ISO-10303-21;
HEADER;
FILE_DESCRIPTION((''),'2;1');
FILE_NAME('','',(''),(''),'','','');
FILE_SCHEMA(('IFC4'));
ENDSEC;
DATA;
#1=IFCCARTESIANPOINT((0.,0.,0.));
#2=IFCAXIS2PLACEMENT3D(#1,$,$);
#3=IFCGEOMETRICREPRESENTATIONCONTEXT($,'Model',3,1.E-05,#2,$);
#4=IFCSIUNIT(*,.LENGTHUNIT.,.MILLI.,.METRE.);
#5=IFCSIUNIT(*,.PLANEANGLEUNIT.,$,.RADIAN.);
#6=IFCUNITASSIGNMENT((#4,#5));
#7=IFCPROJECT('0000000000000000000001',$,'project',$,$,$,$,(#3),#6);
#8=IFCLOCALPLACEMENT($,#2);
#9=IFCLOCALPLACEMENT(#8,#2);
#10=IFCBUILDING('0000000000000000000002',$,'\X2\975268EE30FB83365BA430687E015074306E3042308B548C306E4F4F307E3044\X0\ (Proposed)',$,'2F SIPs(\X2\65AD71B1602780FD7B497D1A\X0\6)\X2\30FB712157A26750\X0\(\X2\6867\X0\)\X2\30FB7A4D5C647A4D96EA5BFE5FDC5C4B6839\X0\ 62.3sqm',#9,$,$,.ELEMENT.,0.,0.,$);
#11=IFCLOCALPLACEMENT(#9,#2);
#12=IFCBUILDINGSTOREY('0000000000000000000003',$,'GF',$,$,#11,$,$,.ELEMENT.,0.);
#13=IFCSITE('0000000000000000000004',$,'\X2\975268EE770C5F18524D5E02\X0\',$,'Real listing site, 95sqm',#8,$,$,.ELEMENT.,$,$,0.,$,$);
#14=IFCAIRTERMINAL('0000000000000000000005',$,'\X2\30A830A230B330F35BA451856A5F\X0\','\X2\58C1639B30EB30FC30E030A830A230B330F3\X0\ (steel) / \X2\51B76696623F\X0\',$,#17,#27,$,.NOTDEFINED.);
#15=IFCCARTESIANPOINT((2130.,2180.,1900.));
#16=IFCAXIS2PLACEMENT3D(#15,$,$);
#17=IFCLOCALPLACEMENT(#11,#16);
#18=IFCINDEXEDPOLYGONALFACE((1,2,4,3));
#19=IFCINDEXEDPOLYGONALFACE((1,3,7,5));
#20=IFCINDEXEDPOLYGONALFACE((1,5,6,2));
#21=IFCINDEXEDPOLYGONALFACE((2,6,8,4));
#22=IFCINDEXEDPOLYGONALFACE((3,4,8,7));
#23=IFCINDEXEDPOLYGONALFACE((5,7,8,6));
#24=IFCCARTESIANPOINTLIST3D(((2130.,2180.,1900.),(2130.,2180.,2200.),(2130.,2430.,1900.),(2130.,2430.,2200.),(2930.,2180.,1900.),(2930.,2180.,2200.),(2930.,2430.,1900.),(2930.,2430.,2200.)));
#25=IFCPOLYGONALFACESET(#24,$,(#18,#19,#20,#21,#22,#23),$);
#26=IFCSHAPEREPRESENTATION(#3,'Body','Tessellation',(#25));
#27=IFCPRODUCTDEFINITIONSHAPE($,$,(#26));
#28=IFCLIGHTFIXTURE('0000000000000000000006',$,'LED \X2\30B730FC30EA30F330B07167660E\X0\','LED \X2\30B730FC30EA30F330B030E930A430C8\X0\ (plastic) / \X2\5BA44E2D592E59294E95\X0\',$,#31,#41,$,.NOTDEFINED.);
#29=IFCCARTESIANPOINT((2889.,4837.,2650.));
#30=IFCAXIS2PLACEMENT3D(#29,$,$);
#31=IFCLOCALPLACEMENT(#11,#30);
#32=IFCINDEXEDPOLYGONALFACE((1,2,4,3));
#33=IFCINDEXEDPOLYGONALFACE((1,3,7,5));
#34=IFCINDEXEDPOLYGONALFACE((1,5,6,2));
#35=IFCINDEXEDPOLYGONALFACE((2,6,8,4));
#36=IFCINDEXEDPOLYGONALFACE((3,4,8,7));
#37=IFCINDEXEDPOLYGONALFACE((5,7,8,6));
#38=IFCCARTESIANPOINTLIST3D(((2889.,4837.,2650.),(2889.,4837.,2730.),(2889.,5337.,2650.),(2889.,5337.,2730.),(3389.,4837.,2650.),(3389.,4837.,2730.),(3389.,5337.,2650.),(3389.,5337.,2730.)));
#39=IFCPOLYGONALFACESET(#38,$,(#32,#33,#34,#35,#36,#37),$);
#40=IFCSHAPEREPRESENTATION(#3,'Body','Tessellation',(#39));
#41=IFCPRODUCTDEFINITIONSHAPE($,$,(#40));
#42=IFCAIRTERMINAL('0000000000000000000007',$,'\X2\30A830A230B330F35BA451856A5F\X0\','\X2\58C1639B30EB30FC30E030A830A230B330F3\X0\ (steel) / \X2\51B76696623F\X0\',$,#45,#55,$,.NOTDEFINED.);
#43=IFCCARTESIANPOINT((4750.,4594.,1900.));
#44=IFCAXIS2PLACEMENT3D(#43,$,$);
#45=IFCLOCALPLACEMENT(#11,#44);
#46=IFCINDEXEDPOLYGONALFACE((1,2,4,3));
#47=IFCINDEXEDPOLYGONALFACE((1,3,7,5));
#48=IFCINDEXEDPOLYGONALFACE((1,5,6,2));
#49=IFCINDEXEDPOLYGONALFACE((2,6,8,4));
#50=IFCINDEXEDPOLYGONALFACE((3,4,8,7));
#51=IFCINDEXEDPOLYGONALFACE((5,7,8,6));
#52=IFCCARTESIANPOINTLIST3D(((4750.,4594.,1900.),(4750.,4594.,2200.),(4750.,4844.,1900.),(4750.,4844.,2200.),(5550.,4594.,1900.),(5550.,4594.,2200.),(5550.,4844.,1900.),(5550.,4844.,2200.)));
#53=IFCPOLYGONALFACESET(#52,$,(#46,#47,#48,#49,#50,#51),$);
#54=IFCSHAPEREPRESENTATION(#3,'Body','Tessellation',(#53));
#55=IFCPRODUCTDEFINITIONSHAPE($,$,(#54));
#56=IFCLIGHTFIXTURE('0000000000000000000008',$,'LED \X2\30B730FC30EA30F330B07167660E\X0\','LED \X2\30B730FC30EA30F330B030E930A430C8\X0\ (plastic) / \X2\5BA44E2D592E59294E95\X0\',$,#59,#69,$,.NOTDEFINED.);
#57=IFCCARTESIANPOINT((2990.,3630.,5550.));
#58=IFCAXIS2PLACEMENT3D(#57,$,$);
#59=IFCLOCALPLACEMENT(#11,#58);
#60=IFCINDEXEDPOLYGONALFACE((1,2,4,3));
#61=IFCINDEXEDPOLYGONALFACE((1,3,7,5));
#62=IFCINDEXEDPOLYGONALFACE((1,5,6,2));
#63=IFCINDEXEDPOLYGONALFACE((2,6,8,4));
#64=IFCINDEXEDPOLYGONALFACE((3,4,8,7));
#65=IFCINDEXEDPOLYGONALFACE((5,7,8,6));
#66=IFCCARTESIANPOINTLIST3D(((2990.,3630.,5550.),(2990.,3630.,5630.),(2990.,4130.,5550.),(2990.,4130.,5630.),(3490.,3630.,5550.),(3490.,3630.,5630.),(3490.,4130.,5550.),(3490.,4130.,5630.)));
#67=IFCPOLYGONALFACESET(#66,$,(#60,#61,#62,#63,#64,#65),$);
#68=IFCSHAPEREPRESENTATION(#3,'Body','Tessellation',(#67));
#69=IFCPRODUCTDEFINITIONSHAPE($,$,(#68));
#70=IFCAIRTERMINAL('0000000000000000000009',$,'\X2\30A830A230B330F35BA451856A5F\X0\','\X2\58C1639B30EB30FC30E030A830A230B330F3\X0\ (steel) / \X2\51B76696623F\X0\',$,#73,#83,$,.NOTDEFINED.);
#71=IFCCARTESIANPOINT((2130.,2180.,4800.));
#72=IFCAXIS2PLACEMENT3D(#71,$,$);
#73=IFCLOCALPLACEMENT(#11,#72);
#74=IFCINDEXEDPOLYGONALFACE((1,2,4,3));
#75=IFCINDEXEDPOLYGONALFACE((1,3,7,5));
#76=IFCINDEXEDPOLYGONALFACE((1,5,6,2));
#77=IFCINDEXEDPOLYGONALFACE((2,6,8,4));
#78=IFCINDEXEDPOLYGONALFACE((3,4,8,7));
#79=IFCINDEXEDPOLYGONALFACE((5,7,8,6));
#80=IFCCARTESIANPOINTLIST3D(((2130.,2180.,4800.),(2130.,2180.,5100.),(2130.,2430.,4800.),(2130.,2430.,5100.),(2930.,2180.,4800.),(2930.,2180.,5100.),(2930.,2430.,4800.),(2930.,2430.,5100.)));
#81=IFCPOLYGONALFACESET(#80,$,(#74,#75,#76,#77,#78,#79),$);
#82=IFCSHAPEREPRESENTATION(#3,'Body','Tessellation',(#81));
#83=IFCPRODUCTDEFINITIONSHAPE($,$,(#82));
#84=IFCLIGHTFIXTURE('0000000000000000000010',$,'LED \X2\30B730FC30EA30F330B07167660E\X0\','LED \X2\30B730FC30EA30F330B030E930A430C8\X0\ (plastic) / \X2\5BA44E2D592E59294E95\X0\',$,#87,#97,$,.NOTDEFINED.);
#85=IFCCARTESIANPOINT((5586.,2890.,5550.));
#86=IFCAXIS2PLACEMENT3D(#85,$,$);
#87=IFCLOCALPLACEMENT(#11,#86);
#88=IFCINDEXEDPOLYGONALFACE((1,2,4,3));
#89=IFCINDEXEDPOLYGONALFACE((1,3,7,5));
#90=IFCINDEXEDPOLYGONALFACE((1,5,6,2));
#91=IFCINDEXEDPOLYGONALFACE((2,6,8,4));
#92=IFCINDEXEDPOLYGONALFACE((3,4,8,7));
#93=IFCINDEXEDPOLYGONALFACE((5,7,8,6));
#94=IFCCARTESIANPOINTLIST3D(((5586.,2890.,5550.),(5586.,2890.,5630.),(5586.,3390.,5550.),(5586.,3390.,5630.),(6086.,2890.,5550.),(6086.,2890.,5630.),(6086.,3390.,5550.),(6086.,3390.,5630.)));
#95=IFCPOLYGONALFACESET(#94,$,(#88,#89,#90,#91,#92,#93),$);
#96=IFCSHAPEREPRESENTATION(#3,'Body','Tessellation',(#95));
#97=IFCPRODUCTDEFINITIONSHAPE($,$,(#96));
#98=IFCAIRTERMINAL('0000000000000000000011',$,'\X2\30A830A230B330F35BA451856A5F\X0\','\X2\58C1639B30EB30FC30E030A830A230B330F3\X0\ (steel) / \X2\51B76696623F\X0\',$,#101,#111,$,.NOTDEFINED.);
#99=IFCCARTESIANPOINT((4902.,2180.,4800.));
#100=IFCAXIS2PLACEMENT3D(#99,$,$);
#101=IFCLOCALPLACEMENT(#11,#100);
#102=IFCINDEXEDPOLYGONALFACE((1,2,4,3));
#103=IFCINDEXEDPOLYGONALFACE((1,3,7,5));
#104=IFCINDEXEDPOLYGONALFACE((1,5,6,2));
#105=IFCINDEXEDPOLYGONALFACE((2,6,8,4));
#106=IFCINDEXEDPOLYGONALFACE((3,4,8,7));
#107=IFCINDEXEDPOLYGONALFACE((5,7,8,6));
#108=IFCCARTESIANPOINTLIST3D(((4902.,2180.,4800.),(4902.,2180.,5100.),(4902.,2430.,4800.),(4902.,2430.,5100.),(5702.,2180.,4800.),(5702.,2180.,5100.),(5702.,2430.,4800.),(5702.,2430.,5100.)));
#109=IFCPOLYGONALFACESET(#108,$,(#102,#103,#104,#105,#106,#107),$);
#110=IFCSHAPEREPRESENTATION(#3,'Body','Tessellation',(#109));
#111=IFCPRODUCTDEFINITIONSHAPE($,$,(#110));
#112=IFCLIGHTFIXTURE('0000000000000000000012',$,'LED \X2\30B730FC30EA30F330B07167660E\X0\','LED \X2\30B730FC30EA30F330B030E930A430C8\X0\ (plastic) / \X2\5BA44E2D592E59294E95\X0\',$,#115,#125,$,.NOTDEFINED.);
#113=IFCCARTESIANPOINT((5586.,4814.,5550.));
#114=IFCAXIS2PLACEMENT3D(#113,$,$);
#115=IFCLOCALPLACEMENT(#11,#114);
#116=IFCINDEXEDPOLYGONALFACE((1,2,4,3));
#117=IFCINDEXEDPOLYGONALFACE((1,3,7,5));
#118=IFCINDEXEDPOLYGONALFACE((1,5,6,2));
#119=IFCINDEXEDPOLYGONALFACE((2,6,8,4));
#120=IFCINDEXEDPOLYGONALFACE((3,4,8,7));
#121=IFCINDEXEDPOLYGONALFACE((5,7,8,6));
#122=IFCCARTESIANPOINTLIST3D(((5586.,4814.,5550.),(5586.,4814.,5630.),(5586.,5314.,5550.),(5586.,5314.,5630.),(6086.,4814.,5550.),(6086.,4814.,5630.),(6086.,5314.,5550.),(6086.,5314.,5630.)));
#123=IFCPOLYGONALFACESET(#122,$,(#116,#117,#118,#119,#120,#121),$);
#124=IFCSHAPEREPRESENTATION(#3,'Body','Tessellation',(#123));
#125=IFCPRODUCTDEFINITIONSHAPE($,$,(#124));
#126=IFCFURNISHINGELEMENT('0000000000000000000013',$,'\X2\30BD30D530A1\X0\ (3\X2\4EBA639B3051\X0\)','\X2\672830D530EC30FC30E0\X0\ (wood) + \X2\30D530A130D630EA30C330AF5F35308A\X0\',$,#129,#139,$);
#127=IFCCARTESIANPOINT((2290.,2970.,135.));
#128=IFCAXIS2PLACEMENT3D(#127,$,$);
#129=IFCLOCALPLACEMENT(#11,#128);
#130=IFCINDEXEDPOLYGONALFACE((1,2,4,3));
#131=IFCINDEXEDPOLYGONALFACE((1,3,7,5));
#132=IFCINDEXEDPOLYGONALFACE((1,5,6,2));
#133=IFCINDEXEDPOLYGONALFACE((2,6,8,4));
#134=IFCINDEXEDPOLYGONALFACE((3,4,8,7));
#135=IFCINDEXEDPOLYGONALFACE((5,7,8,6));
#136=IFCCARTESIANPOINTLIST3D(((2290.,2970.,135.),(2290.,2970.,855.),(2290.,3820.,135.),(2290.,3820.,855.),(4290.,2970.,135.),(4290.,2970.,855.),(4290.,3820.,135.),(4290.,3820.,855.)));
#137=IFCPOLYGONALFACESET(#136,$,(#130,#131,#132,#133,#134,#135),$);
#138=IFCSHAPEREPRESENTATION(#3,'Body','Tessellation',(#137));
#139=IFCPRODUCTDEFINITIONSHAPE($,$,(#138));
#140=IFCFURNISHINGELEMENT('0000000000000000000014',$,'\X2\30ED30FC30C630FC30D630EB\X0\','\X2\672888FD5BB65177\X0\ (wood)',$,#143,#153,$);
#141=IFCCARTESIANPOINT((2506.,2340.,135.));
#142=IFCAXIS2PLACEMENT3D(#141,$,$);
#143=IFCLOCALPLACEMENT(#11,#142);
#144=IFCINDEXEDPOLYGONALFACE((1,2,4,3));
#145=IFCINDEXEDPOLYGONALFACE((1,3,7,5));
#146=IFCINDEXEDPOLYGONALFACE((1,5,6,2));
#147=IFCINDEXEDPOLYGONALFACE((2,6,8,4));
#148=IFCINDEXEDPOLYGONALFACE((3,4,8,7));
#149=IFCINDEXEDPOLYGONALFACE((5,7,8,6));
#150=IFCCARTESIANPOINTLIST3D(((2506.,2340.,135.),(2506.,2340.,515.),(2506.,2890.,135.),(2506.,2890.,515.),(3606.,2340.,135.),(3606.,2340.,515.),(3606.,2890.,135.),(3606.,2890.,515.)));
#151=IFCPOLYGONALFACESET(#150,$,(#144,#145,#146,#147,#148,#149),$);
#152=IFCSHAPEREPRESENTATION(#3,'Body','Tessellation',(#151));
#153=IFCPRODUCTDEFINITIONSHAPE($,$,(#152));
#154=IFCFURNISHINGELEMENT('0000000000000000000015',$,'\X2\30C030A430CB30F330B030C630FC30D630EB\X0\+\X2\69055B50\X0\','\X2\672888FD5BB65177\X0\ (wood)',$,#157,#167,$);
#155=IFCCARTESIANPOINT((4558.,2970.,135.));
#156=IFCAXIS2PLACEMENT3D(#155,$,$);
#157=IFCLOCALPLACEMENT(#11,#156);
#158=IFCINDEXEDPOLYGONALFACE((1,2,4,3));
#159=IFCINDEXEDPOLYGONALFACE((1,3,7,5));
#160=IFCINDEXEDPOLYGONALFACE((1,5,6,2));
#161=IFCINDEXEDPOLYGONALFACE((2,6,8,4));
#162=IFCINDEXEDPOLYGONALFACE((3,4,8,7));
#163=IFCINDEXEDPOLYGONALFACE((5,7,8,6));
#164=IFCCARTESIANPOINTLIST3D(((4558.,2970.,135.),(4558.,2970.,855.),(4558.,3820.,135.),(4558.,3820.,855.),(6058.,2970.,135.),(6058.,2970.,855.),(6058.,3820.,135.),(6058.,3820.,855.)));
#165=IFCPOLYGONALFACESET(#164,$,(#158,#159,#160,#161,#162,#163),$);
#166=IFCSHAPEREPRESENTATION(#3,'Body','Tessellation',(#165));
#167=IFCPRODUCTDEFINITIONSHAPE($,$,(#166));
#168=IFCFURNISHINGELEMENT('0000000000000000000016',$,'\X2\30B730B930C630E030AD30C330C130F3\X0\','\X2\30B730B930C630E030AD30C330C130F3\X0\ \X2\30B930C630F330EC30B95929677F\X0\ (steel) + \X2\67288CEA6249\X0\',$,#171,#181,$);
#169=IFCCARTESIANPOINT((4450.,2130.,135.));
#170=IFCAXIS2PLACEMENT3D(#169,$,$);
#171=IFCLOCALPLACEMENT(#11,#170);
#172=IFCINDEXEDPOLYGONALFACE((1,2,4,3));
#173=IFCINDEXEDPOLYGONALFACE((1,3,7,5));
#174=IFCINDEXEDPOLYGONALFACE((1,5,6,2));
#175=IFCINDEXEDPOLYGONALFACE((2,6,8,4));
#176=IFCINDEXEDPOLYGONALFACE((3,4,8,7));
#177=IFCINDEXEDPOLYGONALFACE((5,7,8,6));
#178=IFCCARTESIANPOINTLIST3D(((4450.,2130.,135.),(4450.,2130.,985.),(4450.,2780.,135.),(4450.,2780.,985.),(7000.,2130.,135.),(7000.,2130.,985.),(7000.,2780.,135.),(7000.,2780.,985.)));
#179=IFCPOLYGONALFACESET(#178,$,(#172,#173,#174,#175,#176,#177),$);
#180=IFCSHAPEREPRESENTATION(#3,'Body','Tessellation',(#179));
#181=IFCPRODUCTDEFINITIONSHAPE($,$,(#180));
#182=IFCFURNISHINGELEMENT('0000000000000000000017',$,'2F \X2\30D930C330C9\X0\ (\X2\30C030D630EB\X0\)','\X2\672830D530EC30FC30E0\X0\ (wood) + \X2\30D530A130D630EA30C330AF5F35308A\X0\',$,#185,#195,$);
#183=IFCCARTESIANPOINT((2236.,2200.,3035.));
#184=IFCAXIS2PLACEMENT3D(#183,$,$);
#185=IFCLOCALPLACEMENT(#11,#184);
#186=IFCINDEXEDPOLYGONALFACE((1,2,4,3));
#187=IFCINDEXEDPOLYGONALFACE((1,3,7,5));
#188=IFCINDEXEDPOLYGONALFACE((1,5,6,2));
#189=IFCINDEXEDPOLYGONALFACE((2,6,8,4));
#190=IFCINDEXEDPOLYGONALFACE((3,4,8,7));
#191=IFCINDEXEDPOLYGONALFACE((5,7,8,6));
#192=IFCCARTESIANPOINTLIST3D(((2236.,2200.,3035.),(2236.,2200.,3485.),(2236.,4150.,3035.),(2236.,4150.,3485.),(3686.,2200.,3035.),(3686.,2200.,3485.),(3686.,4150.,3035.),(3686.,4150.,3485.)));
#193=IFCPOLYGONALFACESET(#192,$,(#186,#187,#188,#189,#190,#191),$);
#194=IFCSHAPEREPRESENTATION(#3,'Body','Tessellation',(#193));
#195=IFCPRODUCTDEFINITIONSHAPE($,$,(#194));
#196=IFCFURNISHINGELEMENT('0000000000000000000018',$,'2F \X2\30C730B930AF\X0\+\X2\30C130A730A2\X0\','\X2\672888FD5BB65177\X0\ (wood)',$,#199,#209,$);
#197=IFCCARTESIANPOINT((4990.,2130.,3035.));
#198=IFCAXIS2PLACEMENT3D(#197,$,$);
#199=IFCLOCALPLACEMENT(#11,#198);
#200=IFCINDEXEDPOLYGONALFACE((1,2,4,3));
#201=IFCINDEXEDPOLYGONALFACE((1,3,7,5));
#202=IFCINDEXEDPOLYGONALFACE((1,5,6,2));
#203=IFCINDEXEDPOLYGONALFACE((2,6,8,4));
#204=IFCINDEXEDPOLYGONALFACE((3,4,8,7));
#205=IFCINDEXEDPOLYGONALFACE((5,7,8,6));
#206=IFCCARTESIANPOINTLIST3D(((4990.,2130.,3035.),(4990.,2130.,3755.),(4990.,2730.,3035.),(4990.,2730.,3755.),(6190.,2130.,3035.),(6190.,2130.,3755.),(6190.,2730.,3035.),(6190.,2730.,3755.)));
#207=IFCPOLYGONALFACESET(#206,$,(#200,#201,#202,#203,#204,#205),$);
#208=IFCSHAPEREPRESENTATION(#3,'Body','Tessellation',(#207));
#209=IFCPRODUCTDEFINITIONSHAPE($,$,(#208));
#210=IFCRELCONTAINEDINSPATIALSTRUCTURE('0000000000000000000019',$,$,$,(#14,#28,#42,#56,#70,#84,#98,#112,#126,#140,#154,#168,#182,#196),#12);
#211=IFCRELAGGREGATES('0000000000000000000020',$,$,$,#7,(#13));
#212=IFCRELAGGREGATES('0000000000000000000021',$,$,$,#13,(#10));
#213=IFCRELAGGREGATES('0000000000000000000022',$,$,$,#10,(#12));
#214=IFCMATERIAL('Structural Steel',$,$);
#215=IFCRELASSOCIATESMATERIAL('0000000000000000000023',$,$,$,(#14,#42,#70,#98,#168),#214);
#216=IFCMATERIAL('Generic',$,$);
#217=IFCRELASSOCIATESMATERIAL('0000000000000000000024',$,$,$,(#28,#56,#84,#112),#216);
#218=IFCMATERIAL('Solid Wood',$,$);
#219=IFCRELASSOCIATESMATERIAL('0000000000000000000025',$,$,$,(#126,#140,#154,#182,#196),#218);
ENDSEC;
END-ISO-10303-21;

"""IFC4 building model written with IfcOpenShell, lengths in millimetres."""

from ifc_helpers import new_model, si_unit, frame, frame_2d, origin, place, context, project, spatial, rectangle, extrude, material, element, save


model = new_model("IFC4")

# Units and contexts
model_context = context("Model", 3, precision=1e-05, world=origin())
ifc_project = project(units=[si_unit("LENGTHUNIT", "METRE", prefix="MILLI"), si_unit("PLANEANGLEUNIT", "RADIAN")], contexts=[model_context])

# Site, building, storey
site_placement = place(None, origin())
site = spatial("IfcSite", under=ifc_project, at=site_placement, Name="青森県弘前市", ObjectType="Real listing site, 95sqm", CompositionType="ELEMENT", RefElevation=0.0)
building_placement = place(site_placement, origin())
building = spatial("IfcBuilding", under=site, at=building_placement, Name="青森・茶室と縁側のある和の住まい (Proposed)", ObjectType="2F SIPs(断熱性能等級6)・無垢材(桧)・積層積雪対応屋根 62.3sqm", CompositionType="ELEMENT", ElevationOfRefHeight=0.0, ElevationOfTerrain=0.0)
storey_placement = place(building_placement, origin())
storey = spatial("IfcBuildingStorey", under=building, at=storey_placement, Name="GF", CompositionType="ELEMENT", Elevation=0.0)

# Shared definitions
ifc_material_1 = material(Name="Solid Wood")

# Shared definitions
ifc_material_2 = material(Name="Structural Steel")

# Shared definitions
ifc_material_3 = material(Name="Generic")

# Air terminal
air_terminal_1_placement = place(storey_placement, frame((2130.0, 2180.0, 1900.0)))
element("IfcAirTerminal", 1, at=air_terminal_1_placement, inside=storey, material=ifc_material_2, Name="エアコン室内機", Description="壁掛ルームエアコン (steel) / 冷暖房", PredefinedType="NOTDEFINED", context=model_context, shape_type="SweptSolid", body=[
    extrude(rectangle(XDim=800.0, YDim=250.0, at=frame_2d((400.0, 125.0))), frame((2130.0, 2180.0, 1900.0)), (0.0, 0.0, 1.0), 300.0),
])

# Light fixture
light_fixture_1_placement = place(storey_placement, frame((2889.0, 4837.0, 2650.0)))
element("IfcLightFixture", 2, at=light_fixture_1_placement, inside=storey, material=ifc_material_3, Name="LED シーリング照明", Description="LED シーリングライト (plastic) / 室中央天井", PredefinedType="NOTDEFINED", context=model_context, shape_type="SweptSolid", body=[
    extrude(rectangle(XDim=500.0, YDim=500.0, at=frame_2d((250.0, 250.0))), frame((2889.0, 4837.0, 2650.0)), (0.0, 0.0, 1.0), 80.0),
])

# Air terminal
air_terminal_2_placement = place(storey_placement, frame((4750.0, 4594.0, 1900.0)))
element("IfcAirTerminal", 3, at=air_terminal_2_placement, inside=storey, material=ifc_material_2, Name="エアコン室内機", Description="壁掛ルームエアコン (steel) / 冷暖房", PredefinedType="NOTDEFINED", context=model_context, shape_type="SweptSolid", body=[
    extrude(rectangle(XDim=800.0, YDim=250.0, at=frame_2d((400.0, 125.0))), frame((4750.0, 4594.0, 1900.0)), (0.0, 0.0, 1.0), 300.0),
])

# Light fixture
light_fixture_2_placement = place(storey_placement, frame((2990.0, 3630.0, 5550.0)))
element("IfcLightFixture", 4, at=light_fixture_2_placement, inside=storey, material=ifc_material_3, Name="LED シーリング照明", Description="LED シーリングライト (plastic) / 室中央天井", PredefinedType="NOTDEFINED", context=model_context, shape_type="SweptSolid", body=[
    extrude(rectangle(XDim=500.0, YDim=500.0, at=frame_2d((250.0, 250.0))), frame((2990.0, 3630.0, 5550.0)), (0.0, 0.0, 1.0), 80.0),
])

# Air terminal
air_terminal_3_placement = place(storey_placement, frame((2130.0, 2180.0, 4800.0)))
element("IfcAirTerminal", 5, at=air_terminal_3_placement, inside=storey, material=ifc_material_2, Name="エアコン室内機", Description="壁掛ルームエアコン (steel) / 冷暖房", PredefinedType="NOTDEFINED", context=model_context, shape_type="SweptSolid", body=[
    extrude(rectangle(XDim=800.0, YDim=250.0, at=frame_2d((400.0, 125.0))), frame((2130.0, 2180.0, 4800.0)), (0.0, 0.0, 1.0), 300.0),
])

# Light fixture
light_fixture_3_placement = place(storey_placement, frame((5586.0, 2890.0, 5550.0)))
element("IfcLightFixture", 6, at=light_fixture_3_placement, inside=storey, material=ifc_material_3, Name="LED シーリング照明", Description="LED シーリングライト (plastic) / 室中央天井", PredefinedType="NOTDEFINED", context=model_context, shape_type="SweptSolid", body=[
    extrude(rectangle(XDim=500.0, YDim=500.0, at=frame_2d((250.0, 250.0))), frame((5586.0, 2890.0, 5550.0)), (0.0, 0.0, 1.0), 80.0),
])

# Air terminal
air_terminal_4_placement = place(storey_placement, frame((4902.0, 2180.0, 4800.0)))
element("IfcAirTerminal", 7, at=air_terminal_4_placement, inside=storey, material=ifc_material_2, Name="エアコン室内機", Description="壁掛ルームエアコン (steel) / 冷暖房", PredefinedType="NOTDEFINED", context=model_context, shape_type="SweptSolid", body=[
    extrude(rectangle(XDim=800.0, YDim=250.0, at=frame_2d((400.0, 125.0))), frame((4902.0, 2180.0, 4800.0)), (0.0, 0.0, 1.0), 300.0),
])

# Light fixture
light_fixture_4_placement = place(storey_placement, frame((5586.0, 4814.0, 5550.0)))
element("IfcLightFixture", 8, at=light_fixture_4_placement, inside=storey, material=ifc_material_3, Name="LED シーリング照明", Description="LED シーリングライト (plastic) / 室中央天井", PredefinedType="NOTDEFINED", context=model_context, shape_type="SweptSolid", body=[
    extrude(rectangle(XDim=500.0, YDim=500.0, at=frame_2d((250.0, 250.0))), frame((5586.0, 4814.0, 5550.0)), (0.0, 0.0, 1.0), 80.0),
])

# Furnishing elements
furnishing_1_placement = place(storey_placement, frame((2290.0, 2970.0, 135.0)))
element("IfcFurnishingElement", 9, at=furnishing_1_placement, inside=storey, material=ifc_material_1, Name="ソファ (3人掛け)", Description="木フレーム (wood) + ファブリック張り", context=model_context, shape_type="SweptSolid", body=[
    extrude(rectangle(XDim=2000.0, YDim=850.0, at=frame_2d((1000.0, 425.0))), frame((2290.0, 2970.0, 135.0)), (0.0, 0.0, 1.0), 720.0),
])
furnishing_2_placement = place(storey_placement, frame((2506.0, 2340.0, 135.0)))
element("IfcFurnishingElement", 10, at=furnishing_2_placement, inside=storey, material=ifc_material_1, Name="ローテーブル", Description="木製家具 (wood)", context=model_context, shape_type="SweptSolid", body=[
    extrude(rectangle(XDim=1100.0, YDim=550.0, at=frame_2d((550.0, 275.0))), frame((2506.0, 2340.0, 135.0)), (0.0, 0.0, 1.0), 380.0),
])
furnishing_3_placement = place(storey_placement, frame((4558.0, 2970.0, 135.0)))
element("IfcFurnishingElement", 11, at=furnishing_3_placement, inside=storey, material=ifc_material_1, Name="ダイニングテーブル+椅子", Description="木製家具 (wood)", context=model_context, shape_type="SweptSolid", body=[
    extrude(rectangle(XDim=1500.0, YDim=850.0, at=frame_2d((750.0, 425.0))), frame((4558.0, 2970.0, 135.0)), (0.0, 0.0, 1.0), 720.0),
])
furnishing_4_placement = place(storey_placement, frame((4450.0, 2130.0, 135.0)))
element("IfcFurnishingElement", 12, at=furnishing_4_placement, inside=storey, material=ifc_material_2, Name="システムキッチン", Description="システムキッチン ステンレス天板 (steel) + 木質扉", context=model_context, shape_type="SweptSolid", body=[
    extrude(rectangle(XDim=2550.0, YDim=650.0, at=frame_2d((1275.0, 325.0))), frame((4450.0, 2130.0, 135.0)), (0.0, 0.0, 1.0), 850.0),
])
furnishing_5_placement = place(storey_placement, frame((2236.0, 2200.0, 3035.0)))
element("IfcFurnishingElement", 13, at=furnishing_5_placement, inside=storey, material=ifc_material_1, Name="2F ベッド (ダブル)", Description="木フレーム (wood) + ファブリック張り", context=model_context, shape_type="SweptSolid", body=[
    extrude(rectangle(XDim=1450.0, YDim=1950.0, at=frame_2d((725.0, 975.0))), frame((2236.0, 2200.0, 3035.0)), (0.0, 0.0, 1.0), 450.0),
])
furnishing_6_placement = place(storey_placement, frame((4990.0, 2130.0, 3035.0)))
element("IfcFurnishingElement", 14, at=furnishing_6_placement, inside=storey, material=ifc_material_1, Name="2F デスク+チェア", Description="木製家具 (wood)", context=model_context, shape_type="SweptSolid", body=[
    extrude(rectangle(XDim=1200.0, YDim=600.0, at=frame_2d((600.0, 300.0))), frame((4990.0, 2130.0, 3035.0)), (0.0, 0.0, 1.0), 720.0),
])

save(model, "model.ifc")
